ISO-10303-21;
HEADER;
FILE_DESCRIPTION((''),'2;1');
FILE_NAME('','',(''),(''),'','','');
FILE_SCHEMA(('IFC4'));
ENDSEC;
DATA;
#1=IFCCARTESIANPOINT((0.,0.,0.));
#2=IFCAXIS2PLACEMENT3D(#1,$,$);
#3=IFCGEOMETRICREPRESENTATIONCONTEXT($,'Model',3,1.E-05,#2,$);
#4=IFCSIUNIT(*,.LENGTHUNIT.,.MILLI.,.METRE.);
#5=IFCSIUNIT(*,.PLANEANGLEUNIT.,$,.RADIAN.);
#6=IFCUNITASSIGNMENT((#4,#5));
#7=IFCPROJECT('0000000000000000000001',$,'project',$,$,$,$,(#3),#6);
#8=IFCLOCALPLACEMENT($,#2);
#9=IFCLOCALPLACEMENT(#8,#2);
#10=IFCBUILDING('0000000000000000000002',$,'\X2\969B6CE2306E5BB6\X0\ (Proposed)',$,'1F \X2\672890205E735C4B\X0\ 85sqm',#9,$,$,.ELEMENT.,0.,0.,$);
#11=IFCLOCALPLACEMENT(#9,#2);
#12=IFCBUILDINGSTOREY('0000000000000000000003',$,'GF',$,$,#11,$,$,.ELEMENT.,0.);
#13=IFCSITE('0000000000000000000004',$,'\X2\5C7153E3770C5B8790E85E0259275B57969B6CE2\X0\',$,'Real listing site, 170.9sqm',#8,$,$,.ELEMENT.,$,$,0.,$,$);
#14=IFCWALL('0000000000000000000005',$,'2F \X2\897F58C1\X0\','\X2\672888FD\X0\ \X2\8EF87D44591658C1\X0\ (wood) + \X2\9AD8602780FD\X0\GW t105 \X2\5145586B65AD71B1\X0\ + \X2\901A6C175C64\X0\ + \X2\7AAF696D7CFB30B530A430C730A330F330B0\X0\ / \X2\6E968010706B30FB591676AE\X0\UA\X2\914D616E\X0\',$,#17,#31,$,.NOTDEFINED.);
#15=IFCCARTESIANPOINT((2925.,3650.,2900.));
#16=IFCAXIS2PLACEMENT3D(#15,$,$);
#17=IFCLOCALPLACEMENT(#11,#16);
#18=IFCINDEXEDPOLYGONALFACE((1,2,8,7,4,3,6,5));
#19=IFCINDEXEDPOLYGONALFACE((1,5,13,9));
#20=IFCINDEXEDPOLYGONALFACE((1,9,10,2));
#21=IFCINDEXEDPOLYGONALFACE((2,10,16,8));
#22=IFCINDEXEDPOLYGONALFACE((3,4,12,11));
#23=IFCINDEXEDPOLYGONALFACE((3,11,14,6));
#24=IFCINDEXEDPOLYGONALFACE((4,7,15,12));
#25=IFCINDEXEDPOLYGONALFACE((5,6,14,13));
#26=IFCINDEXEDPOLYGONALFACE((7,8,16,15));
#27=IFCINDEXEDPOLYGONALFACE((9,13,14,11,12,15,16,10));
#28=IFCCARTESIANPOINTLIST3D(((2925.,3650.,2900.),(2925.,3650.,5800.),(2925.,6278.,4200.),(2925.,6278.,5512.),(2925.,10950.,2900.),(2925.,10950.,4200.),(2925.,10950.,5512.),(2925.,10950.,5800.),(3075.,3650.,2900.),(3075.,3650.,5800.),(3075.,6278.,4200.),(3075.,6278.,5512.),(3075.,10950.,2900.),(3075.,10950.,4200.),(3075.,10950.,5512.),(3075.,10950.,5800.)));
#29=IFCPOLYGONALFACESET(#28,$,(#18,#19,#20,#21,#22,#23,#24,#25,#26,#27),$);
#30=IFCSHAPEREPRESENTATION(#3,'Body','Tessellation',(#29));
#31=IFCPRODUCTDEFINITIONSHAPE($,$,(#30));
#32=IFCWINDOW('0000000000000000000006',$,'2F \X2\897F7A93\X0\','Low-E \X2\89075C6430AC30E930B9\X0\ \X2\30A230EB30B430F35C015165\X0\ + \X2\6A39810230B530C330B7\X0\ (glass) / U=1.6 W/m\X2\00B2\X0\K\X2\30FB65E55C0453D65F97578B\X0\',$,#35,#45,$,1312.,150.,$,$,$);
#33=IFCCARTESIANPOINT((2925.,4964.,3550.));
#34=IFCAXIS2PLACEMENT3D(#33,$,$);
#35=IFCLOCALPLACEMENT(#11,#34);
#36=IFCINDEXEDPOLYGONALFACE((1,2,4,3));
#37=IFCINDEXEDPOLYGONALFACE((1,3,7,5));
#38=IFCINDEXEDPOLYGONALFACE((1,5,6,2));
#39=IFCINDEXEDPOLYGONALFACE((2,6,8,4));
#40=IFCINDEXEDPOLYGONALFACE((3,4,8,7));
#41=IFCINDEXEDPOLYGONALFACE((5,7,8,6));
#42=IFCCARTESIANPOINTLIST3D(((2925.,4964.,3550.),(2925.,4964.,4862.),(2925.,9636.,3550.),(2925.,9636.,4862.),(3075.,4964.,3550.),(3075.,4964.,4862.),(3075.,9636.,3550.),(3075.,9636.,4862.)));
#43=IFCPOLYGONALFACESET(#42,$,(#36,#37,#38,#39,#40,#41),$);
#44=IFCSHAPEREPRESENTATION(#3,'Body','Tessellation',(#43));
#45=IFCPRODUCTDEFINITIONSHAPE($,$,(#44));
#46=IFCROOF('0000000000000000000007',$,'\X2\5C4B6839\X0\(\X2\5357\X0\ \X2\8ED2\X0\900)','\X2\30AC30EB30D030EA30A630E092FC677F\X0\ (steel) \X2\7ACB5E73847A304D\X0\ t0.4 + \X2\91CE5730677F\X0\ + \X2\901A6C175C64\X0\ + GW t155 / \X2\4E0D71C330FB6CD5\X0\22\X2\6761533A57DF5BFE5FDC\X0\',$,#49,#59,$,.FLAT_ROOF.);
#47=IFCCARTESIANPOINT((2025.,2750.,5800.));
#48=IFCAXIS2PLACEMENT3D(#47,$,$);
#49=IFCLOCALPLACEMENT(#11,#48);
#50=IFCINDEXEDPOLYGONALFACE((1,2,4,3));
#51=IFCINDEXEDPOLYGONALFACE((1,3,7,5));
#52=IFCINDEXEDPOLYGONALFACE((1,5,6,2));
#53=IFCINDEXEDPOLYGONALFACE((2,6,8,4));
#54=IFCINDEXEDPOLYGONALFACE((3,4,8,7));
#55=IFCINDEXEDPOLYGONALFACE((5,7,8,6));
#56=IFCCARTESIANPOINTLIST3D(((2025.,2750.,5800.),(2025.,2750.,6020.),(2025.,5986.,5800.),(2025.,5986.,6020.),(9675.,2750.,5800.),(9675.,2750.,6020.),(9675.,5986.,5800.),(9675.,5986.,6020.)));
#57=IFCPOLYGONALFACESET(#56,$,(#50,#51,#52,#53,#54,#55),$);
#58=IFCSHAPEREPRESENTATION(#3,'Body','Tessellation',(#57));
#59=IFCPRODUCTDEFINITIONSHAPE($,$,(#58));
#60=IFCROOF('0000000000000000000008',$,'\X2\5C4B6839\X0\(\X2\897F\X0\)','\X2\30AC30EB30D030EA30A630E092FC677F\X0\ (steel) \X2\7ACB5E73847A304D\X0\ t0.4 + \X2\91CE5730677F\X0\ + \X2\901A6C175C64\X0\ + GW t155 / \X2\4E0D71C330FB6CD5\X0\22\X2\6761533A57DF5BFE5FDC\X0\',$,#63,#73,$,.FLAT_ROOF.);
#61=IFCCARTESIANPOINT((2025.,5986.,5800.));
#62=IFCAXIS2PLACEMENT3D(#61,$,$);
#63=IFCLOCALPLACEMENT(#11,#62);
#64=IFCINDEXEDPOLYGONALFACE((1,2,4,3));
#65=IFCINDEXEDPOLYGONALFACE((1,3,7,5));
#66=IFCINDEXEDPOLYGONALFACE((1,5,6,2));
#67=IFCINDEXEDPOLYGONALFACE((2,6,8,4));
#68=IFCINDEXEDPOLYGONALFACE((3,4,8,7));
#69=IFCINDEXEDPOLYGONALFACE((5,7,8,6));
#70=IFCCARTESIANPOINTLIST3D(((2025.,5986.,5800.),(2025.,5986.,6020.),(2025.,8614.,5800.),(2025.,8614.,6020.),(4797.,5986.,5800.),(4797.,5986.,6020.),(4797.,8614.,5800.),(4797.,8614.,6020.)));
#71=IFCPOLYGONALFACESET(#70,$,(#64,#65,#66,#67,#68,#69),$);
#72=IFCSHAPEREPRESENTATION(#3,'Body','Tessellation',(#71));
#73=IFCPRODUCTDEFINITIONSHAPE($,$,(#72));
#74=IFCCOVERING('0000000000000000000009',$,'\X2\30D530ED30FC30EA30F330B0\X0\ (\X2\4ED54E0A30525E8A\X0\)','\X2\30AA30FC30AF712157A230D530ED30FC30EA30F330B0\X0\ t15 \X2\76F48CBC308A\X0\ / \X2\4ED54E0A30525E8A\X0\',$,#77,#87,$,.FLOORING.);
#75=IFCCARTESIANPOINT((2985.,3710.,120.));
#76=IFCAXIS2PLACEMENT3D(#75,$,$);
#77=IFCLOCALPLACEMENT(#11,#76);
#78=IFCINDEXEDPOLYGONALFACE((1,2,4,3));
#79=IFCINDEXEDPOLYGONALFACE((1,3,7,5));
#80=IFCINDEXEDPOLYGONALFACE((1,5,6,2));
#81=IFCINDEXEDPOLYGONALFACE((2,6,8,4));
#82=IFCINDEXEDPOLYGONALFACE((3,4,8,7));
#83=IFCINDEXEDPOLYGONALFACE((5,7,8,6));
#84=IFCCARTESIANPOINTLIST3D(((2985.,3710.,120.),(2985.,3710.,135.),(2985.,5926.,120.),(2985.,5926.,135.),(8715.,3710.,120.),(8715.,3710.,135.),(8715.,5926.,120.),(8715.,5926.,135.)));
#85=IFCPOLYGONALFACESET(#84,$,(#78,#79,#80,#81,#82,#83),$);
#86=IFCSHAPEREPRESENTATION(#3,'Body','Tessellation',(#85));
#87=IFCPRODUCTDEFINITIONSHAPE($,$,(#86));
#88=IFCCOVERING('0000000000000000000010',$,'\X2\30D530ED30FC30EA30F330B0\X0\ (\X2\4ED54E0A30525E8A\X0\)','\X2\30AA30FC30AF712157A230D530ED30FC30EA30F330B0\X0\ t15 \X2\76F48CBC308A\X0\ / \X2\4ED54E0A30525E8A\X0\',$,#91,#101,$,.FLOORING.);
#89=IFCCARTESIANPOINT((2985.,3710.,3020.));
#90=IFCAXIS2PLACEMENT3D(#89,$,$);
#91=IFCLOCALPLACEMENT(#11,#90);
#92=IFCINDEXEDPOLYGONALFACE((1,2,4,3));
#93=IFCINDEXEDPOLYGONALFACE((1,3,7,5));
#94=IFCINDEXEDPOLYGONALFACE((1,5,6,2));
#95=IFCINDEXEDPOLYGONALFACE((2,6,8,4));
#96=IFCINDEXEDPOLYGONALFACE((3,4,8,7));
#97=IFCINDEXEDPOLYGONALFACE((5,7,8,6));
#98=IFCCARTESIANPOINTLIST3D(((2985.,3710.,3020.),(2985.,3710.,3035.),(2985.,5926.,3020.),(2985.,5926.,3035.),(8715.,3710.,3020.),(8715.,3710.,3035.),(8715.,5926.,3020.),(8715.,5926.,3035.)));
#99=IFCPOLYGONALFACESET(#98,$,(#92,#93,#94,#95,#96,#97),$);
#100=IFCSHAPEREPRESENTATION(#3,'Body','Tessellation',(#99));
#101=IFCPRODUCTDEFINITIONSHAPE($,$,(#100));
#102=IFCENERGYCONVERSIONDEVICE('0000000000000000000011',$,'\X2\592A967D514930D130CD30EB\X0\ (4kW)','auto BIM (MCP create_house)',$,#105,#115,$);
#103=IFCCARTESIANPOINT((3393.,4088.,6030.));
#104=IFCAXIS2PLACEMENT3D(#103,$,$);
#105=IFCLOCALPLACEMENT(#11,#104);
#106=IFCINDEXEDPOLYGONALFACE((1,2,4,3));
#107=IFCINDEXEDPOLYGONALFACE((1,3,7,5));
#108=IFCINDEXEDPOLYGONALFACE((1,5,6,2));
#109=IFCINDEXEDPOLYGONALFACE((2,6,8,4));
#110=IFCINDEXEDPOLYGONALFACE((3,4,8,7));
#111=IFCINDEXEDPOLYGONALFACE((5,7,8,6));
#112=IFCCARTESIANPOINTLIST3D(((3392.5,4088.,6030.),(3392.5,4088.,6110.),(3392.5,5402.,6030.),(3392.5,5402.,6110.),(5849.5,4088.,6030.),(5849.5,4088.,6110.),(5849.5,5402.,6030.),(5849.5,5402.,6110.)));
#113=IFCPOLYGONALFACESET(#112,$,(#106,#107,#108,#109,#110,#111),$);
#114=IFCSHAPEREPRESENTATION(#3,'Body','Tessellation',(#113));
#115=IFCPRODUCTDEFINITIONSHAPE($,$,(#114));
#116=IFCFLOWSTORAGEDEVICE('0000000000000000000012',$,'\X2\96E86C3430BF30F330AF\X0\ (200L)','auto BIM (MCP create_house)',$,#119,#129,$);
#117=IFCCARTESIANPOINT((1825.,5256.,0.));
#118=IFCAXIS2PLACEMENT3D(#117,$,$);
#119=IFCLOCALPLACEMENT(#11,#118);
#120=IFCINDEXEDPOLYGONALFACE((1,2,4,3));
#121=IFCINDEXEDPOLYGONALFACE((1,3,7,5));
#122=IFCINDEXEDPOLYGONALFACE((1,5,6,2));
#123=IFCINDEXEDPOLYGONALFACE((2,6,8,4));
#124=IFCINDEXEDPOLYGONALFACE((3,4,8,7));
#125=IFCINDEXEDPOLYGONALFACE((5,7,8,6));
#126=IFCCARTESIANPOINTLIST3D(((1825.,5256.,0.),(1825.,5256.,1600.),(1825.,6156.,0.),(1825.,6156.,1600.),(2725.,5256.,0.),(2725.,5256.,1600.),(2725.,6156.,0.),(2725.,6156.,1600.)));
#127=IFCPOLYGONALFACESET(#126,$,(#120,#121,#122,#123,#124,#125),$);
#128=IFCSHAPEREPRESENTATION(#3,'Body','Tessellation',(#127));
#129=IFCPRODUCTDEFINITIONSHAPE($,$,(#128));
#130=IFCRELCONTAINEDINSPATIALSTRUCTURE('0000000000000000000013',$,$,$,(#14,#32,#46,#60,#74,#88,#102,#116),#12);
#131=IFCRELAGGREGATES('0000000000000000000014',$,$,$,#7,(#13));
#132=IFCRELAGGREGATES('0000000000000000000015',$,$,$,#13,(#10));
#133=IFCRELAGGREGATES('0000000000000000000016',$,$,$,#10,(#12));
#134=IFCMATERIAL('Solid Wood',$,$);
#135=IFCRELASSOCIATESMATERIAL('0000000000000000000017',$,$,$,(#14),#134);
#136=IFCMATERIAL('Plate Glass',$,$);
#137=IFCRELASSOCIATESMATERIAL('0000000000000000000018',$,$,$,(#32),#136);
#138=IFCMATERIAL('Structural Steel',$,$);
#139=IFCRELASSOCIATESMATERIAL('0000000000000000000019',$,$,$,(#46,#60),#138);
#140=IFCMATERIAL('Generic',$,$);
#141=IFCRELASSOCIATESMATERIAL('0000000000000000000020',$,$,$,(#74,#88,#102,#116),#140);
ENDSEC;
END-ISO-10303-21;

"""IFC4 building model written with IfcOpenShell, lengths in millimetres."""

from ifc_helpers import new_model, si_unit, frame, frame_2d, origin, place, context, project, spatial, rectangle, extrude, material, element, fill, save


model = new_model("IFC4")

# Units and contexts
model_context = context("Model", 3, precision=1e-05, world=origin())
ifc_project = project(units=[si_unit("LENGTHUNIT", "METRE", prefix="MILLI"), si_unit("PLANEANGLEUNIT", "RADIAN")], contexts=[model_context])

# Site, building, storey
site_placement = place(None, origin())
site = spatial("IfcSite", under=ifc_project, at=site_placement, Name="山口県宇部市大字際波", ObjectType="Real listing site, 170.9sqm", CompositionType="ELEMENT", RefElevation=0.0)
building_placement = place(site_placement, origin())
building = spatial("IfcBuilding", under=site, at=building_placement, Name="際波の家 (Proposed)", ObjectType="1F 木造平屋 85sqm", CompositionType="ELEMENT", ElevationOfRefHeight=0.0, ElevationOfTerrain=0.0)
storey_placement = place(building_placement, origin())
storey = spatial("IfcBuildingStorey", under=building, at=storey_placement, Name="GF", CompositionType="ELEMENT", Elevation=0.0)

# Shared definitions
ifc_material_1 = material(Name="Solid Wood")
ifc_material_2 = material(Name="Generic")

# Shared definitions
ifc_material_3 = material(Name="Plate Glass")

# Wall, opening, window
wall_1_placement = place(storey_placement, frame((2925.0, 3650.0, 2900.0)))
wall_1 = element("IfcWall", 1, at=wall_1_placement, inside=storey, material=ifc_material_1, Name="2F 西壁", Description="木製 軸組外壁 (wood) + 高性能GW t105 充填断熱 + 通気層 + 窯業系サイディング / 準耐火・外皮UA配慮", PredefinedType="NOTDEFINED", context=model_context, shape_type="SweptSolid", body=[
    extrude(rectangle(XDim=150.0, YDim=7300.0, at=frame_2d((75.0, 3650.0))), frame((2925.0, 3650.0, 2900.0)), (0.0, 0.0, 1.0), 2900.0),
])
opening_1_placement = place(storey_placement, frame((2925.0, 4964.0, 3550.0)))
opening_1 = element("IfcOpeningElement", 2, at=opening_1_placement, cuts=wall_1, PredefinedType="NOTDEFINED", context=model_context, shape_type="SweptSolid", body=[
    extrude(rectangle(XDim=150.0, YDim=4672.0, at=frame_2d((75.0, 2336.0))), frame((2925.0, 4964.0, 3550.0)), (0.0, 0.0, 1.0), 1312.0),
])
window_1_placement = place(storey_placement, frame((2925.0, 4964.0, 3550.0)))
window_1 = element("IfcWindow", 3, at=window_1_placement, inside=storey, material=ifc_material_3, Name="2F 西窓", Description="Low-E 複層ガラス アルゴン封入 + 樹脂サッシ (glass) / U=1.6 W/m²K・日射取得型", OverallHeight=1312.0, OverallWidth=150.0, context=model_context, shape_type="SweptSolid", body=[
    extrude(rectangle(XDim=150.0, YDim=4672.0, at=frame_2d((75.0, 2336.0))), frame((2925.0, 4964.0, 3550.0)), (0.0, 0.0, 1.0), 1312.0),
])
fill(opening_1, window_1)

# Roofs
ifc_material_4 = material(Name="Structural Steel")
roof_1_placement = place(storey_placement, frame((2025.0, 2750.0, 5800.0)))
element("IfcRoof", 4, at=roof_1_placement, inside=storey, material=ifc_material_4, Name="屋根(南 軒900)", Description="ガルバリウム鋼板 (steel) 立平葺き t0.4 + 野地板 + 通気層 + GW t155 / 不燃・法22条区域対応", PredefinedType="FLAT_ROOF", context=model_context, shape_type="SweptSolid", body=[
    extrude(rectangle(XDim=7650.0, YDim=3236.0, at=frame_2d((3825.0, 1618.0))), frame((2025.0, 2750.0, 5800.0)), (0.0, 0.0, 1.0), 220.0),
])
roof_2_placement = place(storey_placement, frame((2025.0, 5986.0, 5800.0)))
element("IfcRoof", 5, at=roof_2_placement, inside=storey, material=ifc_material_4, Name="屋根(西)", Description="ガルバリウム鋼板 (steel) 立平葺き t0.4 + 野地板 + 通気層 + GW t155 / 不燃・法22条区域対応", PredefinedType="FLAT_ROOF", context=model_context, shape_type="SweptSolid", body=[
    extrude(rectangle(XDim=2772.0, YDim=2628.0, at=frame_2d((1386.0, 1314.0))), frame((2025.0, 5986.0, 5800.0)), (0.0, 0.0, 1.0), 220.0),
])

# Coverings
covering_1_placement = place(storey_placement, frame((2985.0, 3710.0, 120.0)))
element("IfcCovering", 6, at=covering_1_placement, inside=storey, material=ifc_material_2, Name="フローリング (仕上げ床)", Description="オーク無垢フローリング t15 直貼り / 仕上げ床", PredefinedType="FLOORING", context=model_context, shape_type="SweptSolid", body=[
    extrude(rectangle(XDim=5730.0, YDim=2216.0, at=frame_2d((2865.0, 1108.0))), frame((2985.0, 3710.0, 120.0)), (0.0, 0.0, 1.0), 15.0),
])
covering_2_placement = place(storey_placement, frame((2985.0, 3710.0, 3020.0)))
element("IfcCovering", 7, at=covering_2_placement, inside=storey, material=ifc_material_2, Name="フローリング (仕上げ床)", Description="オーク無垢フローリング t15 直貼り / 仕上げ床", PredefinedType="FLOORING", context=model_context, shape_type="SweptSolid", body=[
    extrude(rectangle(XDim=5730.0, YDim=2216.0, at=frame_2d((2865.0, 1108.0))), frame((2985.0, 3710.0, 3020.0)), (0.0, 0.0, 1.0), 15.0),
])

# Energy conversion device
energy_conversion_device_placement = place(storey_placement, frame((3393.0, 4088.0, 6030.0)))
element("IfcEnergyConversionDevice", 8, at=energy_conversion_device_placement, inside=storey, material=ifc_material_2, Name="太陽光パネル (4kW)", Description="auto BIM (MCP create_house)", context=model_context, shape_type="SweptSolid", body=[
    extrude(rectangle(XDim=2457.0, YDim=1314.0, at=frame_2d((1228.0, 657.0))), frame((3393.0, 4088.0, 6030.0)), (0.0, 0.0, 1.0), 80.0),
])

# Flow storage device
flow_storage_device_placement = place(storey_placement, frame((1825.0, 5256.0, 0.0)))
element("IfcFlowStorageDevice", 9, at=flow_storage_device_placement, inside=storey, material=ifc_material_2, Name="雨水タンク (200L)", Description="auto BIM (MCP create_house)", context=model_context, shape_type="SweptSolid", body=[
    extrude(rectangle(XDim=900.0, YDim=900.0, at=frame_2d((450.0, 450.0))), frame((1825.0, 5256.0, 0.0)), (0.0, 0.0, 1.0), 1600.0),
])

save(model, "model.ifc")
